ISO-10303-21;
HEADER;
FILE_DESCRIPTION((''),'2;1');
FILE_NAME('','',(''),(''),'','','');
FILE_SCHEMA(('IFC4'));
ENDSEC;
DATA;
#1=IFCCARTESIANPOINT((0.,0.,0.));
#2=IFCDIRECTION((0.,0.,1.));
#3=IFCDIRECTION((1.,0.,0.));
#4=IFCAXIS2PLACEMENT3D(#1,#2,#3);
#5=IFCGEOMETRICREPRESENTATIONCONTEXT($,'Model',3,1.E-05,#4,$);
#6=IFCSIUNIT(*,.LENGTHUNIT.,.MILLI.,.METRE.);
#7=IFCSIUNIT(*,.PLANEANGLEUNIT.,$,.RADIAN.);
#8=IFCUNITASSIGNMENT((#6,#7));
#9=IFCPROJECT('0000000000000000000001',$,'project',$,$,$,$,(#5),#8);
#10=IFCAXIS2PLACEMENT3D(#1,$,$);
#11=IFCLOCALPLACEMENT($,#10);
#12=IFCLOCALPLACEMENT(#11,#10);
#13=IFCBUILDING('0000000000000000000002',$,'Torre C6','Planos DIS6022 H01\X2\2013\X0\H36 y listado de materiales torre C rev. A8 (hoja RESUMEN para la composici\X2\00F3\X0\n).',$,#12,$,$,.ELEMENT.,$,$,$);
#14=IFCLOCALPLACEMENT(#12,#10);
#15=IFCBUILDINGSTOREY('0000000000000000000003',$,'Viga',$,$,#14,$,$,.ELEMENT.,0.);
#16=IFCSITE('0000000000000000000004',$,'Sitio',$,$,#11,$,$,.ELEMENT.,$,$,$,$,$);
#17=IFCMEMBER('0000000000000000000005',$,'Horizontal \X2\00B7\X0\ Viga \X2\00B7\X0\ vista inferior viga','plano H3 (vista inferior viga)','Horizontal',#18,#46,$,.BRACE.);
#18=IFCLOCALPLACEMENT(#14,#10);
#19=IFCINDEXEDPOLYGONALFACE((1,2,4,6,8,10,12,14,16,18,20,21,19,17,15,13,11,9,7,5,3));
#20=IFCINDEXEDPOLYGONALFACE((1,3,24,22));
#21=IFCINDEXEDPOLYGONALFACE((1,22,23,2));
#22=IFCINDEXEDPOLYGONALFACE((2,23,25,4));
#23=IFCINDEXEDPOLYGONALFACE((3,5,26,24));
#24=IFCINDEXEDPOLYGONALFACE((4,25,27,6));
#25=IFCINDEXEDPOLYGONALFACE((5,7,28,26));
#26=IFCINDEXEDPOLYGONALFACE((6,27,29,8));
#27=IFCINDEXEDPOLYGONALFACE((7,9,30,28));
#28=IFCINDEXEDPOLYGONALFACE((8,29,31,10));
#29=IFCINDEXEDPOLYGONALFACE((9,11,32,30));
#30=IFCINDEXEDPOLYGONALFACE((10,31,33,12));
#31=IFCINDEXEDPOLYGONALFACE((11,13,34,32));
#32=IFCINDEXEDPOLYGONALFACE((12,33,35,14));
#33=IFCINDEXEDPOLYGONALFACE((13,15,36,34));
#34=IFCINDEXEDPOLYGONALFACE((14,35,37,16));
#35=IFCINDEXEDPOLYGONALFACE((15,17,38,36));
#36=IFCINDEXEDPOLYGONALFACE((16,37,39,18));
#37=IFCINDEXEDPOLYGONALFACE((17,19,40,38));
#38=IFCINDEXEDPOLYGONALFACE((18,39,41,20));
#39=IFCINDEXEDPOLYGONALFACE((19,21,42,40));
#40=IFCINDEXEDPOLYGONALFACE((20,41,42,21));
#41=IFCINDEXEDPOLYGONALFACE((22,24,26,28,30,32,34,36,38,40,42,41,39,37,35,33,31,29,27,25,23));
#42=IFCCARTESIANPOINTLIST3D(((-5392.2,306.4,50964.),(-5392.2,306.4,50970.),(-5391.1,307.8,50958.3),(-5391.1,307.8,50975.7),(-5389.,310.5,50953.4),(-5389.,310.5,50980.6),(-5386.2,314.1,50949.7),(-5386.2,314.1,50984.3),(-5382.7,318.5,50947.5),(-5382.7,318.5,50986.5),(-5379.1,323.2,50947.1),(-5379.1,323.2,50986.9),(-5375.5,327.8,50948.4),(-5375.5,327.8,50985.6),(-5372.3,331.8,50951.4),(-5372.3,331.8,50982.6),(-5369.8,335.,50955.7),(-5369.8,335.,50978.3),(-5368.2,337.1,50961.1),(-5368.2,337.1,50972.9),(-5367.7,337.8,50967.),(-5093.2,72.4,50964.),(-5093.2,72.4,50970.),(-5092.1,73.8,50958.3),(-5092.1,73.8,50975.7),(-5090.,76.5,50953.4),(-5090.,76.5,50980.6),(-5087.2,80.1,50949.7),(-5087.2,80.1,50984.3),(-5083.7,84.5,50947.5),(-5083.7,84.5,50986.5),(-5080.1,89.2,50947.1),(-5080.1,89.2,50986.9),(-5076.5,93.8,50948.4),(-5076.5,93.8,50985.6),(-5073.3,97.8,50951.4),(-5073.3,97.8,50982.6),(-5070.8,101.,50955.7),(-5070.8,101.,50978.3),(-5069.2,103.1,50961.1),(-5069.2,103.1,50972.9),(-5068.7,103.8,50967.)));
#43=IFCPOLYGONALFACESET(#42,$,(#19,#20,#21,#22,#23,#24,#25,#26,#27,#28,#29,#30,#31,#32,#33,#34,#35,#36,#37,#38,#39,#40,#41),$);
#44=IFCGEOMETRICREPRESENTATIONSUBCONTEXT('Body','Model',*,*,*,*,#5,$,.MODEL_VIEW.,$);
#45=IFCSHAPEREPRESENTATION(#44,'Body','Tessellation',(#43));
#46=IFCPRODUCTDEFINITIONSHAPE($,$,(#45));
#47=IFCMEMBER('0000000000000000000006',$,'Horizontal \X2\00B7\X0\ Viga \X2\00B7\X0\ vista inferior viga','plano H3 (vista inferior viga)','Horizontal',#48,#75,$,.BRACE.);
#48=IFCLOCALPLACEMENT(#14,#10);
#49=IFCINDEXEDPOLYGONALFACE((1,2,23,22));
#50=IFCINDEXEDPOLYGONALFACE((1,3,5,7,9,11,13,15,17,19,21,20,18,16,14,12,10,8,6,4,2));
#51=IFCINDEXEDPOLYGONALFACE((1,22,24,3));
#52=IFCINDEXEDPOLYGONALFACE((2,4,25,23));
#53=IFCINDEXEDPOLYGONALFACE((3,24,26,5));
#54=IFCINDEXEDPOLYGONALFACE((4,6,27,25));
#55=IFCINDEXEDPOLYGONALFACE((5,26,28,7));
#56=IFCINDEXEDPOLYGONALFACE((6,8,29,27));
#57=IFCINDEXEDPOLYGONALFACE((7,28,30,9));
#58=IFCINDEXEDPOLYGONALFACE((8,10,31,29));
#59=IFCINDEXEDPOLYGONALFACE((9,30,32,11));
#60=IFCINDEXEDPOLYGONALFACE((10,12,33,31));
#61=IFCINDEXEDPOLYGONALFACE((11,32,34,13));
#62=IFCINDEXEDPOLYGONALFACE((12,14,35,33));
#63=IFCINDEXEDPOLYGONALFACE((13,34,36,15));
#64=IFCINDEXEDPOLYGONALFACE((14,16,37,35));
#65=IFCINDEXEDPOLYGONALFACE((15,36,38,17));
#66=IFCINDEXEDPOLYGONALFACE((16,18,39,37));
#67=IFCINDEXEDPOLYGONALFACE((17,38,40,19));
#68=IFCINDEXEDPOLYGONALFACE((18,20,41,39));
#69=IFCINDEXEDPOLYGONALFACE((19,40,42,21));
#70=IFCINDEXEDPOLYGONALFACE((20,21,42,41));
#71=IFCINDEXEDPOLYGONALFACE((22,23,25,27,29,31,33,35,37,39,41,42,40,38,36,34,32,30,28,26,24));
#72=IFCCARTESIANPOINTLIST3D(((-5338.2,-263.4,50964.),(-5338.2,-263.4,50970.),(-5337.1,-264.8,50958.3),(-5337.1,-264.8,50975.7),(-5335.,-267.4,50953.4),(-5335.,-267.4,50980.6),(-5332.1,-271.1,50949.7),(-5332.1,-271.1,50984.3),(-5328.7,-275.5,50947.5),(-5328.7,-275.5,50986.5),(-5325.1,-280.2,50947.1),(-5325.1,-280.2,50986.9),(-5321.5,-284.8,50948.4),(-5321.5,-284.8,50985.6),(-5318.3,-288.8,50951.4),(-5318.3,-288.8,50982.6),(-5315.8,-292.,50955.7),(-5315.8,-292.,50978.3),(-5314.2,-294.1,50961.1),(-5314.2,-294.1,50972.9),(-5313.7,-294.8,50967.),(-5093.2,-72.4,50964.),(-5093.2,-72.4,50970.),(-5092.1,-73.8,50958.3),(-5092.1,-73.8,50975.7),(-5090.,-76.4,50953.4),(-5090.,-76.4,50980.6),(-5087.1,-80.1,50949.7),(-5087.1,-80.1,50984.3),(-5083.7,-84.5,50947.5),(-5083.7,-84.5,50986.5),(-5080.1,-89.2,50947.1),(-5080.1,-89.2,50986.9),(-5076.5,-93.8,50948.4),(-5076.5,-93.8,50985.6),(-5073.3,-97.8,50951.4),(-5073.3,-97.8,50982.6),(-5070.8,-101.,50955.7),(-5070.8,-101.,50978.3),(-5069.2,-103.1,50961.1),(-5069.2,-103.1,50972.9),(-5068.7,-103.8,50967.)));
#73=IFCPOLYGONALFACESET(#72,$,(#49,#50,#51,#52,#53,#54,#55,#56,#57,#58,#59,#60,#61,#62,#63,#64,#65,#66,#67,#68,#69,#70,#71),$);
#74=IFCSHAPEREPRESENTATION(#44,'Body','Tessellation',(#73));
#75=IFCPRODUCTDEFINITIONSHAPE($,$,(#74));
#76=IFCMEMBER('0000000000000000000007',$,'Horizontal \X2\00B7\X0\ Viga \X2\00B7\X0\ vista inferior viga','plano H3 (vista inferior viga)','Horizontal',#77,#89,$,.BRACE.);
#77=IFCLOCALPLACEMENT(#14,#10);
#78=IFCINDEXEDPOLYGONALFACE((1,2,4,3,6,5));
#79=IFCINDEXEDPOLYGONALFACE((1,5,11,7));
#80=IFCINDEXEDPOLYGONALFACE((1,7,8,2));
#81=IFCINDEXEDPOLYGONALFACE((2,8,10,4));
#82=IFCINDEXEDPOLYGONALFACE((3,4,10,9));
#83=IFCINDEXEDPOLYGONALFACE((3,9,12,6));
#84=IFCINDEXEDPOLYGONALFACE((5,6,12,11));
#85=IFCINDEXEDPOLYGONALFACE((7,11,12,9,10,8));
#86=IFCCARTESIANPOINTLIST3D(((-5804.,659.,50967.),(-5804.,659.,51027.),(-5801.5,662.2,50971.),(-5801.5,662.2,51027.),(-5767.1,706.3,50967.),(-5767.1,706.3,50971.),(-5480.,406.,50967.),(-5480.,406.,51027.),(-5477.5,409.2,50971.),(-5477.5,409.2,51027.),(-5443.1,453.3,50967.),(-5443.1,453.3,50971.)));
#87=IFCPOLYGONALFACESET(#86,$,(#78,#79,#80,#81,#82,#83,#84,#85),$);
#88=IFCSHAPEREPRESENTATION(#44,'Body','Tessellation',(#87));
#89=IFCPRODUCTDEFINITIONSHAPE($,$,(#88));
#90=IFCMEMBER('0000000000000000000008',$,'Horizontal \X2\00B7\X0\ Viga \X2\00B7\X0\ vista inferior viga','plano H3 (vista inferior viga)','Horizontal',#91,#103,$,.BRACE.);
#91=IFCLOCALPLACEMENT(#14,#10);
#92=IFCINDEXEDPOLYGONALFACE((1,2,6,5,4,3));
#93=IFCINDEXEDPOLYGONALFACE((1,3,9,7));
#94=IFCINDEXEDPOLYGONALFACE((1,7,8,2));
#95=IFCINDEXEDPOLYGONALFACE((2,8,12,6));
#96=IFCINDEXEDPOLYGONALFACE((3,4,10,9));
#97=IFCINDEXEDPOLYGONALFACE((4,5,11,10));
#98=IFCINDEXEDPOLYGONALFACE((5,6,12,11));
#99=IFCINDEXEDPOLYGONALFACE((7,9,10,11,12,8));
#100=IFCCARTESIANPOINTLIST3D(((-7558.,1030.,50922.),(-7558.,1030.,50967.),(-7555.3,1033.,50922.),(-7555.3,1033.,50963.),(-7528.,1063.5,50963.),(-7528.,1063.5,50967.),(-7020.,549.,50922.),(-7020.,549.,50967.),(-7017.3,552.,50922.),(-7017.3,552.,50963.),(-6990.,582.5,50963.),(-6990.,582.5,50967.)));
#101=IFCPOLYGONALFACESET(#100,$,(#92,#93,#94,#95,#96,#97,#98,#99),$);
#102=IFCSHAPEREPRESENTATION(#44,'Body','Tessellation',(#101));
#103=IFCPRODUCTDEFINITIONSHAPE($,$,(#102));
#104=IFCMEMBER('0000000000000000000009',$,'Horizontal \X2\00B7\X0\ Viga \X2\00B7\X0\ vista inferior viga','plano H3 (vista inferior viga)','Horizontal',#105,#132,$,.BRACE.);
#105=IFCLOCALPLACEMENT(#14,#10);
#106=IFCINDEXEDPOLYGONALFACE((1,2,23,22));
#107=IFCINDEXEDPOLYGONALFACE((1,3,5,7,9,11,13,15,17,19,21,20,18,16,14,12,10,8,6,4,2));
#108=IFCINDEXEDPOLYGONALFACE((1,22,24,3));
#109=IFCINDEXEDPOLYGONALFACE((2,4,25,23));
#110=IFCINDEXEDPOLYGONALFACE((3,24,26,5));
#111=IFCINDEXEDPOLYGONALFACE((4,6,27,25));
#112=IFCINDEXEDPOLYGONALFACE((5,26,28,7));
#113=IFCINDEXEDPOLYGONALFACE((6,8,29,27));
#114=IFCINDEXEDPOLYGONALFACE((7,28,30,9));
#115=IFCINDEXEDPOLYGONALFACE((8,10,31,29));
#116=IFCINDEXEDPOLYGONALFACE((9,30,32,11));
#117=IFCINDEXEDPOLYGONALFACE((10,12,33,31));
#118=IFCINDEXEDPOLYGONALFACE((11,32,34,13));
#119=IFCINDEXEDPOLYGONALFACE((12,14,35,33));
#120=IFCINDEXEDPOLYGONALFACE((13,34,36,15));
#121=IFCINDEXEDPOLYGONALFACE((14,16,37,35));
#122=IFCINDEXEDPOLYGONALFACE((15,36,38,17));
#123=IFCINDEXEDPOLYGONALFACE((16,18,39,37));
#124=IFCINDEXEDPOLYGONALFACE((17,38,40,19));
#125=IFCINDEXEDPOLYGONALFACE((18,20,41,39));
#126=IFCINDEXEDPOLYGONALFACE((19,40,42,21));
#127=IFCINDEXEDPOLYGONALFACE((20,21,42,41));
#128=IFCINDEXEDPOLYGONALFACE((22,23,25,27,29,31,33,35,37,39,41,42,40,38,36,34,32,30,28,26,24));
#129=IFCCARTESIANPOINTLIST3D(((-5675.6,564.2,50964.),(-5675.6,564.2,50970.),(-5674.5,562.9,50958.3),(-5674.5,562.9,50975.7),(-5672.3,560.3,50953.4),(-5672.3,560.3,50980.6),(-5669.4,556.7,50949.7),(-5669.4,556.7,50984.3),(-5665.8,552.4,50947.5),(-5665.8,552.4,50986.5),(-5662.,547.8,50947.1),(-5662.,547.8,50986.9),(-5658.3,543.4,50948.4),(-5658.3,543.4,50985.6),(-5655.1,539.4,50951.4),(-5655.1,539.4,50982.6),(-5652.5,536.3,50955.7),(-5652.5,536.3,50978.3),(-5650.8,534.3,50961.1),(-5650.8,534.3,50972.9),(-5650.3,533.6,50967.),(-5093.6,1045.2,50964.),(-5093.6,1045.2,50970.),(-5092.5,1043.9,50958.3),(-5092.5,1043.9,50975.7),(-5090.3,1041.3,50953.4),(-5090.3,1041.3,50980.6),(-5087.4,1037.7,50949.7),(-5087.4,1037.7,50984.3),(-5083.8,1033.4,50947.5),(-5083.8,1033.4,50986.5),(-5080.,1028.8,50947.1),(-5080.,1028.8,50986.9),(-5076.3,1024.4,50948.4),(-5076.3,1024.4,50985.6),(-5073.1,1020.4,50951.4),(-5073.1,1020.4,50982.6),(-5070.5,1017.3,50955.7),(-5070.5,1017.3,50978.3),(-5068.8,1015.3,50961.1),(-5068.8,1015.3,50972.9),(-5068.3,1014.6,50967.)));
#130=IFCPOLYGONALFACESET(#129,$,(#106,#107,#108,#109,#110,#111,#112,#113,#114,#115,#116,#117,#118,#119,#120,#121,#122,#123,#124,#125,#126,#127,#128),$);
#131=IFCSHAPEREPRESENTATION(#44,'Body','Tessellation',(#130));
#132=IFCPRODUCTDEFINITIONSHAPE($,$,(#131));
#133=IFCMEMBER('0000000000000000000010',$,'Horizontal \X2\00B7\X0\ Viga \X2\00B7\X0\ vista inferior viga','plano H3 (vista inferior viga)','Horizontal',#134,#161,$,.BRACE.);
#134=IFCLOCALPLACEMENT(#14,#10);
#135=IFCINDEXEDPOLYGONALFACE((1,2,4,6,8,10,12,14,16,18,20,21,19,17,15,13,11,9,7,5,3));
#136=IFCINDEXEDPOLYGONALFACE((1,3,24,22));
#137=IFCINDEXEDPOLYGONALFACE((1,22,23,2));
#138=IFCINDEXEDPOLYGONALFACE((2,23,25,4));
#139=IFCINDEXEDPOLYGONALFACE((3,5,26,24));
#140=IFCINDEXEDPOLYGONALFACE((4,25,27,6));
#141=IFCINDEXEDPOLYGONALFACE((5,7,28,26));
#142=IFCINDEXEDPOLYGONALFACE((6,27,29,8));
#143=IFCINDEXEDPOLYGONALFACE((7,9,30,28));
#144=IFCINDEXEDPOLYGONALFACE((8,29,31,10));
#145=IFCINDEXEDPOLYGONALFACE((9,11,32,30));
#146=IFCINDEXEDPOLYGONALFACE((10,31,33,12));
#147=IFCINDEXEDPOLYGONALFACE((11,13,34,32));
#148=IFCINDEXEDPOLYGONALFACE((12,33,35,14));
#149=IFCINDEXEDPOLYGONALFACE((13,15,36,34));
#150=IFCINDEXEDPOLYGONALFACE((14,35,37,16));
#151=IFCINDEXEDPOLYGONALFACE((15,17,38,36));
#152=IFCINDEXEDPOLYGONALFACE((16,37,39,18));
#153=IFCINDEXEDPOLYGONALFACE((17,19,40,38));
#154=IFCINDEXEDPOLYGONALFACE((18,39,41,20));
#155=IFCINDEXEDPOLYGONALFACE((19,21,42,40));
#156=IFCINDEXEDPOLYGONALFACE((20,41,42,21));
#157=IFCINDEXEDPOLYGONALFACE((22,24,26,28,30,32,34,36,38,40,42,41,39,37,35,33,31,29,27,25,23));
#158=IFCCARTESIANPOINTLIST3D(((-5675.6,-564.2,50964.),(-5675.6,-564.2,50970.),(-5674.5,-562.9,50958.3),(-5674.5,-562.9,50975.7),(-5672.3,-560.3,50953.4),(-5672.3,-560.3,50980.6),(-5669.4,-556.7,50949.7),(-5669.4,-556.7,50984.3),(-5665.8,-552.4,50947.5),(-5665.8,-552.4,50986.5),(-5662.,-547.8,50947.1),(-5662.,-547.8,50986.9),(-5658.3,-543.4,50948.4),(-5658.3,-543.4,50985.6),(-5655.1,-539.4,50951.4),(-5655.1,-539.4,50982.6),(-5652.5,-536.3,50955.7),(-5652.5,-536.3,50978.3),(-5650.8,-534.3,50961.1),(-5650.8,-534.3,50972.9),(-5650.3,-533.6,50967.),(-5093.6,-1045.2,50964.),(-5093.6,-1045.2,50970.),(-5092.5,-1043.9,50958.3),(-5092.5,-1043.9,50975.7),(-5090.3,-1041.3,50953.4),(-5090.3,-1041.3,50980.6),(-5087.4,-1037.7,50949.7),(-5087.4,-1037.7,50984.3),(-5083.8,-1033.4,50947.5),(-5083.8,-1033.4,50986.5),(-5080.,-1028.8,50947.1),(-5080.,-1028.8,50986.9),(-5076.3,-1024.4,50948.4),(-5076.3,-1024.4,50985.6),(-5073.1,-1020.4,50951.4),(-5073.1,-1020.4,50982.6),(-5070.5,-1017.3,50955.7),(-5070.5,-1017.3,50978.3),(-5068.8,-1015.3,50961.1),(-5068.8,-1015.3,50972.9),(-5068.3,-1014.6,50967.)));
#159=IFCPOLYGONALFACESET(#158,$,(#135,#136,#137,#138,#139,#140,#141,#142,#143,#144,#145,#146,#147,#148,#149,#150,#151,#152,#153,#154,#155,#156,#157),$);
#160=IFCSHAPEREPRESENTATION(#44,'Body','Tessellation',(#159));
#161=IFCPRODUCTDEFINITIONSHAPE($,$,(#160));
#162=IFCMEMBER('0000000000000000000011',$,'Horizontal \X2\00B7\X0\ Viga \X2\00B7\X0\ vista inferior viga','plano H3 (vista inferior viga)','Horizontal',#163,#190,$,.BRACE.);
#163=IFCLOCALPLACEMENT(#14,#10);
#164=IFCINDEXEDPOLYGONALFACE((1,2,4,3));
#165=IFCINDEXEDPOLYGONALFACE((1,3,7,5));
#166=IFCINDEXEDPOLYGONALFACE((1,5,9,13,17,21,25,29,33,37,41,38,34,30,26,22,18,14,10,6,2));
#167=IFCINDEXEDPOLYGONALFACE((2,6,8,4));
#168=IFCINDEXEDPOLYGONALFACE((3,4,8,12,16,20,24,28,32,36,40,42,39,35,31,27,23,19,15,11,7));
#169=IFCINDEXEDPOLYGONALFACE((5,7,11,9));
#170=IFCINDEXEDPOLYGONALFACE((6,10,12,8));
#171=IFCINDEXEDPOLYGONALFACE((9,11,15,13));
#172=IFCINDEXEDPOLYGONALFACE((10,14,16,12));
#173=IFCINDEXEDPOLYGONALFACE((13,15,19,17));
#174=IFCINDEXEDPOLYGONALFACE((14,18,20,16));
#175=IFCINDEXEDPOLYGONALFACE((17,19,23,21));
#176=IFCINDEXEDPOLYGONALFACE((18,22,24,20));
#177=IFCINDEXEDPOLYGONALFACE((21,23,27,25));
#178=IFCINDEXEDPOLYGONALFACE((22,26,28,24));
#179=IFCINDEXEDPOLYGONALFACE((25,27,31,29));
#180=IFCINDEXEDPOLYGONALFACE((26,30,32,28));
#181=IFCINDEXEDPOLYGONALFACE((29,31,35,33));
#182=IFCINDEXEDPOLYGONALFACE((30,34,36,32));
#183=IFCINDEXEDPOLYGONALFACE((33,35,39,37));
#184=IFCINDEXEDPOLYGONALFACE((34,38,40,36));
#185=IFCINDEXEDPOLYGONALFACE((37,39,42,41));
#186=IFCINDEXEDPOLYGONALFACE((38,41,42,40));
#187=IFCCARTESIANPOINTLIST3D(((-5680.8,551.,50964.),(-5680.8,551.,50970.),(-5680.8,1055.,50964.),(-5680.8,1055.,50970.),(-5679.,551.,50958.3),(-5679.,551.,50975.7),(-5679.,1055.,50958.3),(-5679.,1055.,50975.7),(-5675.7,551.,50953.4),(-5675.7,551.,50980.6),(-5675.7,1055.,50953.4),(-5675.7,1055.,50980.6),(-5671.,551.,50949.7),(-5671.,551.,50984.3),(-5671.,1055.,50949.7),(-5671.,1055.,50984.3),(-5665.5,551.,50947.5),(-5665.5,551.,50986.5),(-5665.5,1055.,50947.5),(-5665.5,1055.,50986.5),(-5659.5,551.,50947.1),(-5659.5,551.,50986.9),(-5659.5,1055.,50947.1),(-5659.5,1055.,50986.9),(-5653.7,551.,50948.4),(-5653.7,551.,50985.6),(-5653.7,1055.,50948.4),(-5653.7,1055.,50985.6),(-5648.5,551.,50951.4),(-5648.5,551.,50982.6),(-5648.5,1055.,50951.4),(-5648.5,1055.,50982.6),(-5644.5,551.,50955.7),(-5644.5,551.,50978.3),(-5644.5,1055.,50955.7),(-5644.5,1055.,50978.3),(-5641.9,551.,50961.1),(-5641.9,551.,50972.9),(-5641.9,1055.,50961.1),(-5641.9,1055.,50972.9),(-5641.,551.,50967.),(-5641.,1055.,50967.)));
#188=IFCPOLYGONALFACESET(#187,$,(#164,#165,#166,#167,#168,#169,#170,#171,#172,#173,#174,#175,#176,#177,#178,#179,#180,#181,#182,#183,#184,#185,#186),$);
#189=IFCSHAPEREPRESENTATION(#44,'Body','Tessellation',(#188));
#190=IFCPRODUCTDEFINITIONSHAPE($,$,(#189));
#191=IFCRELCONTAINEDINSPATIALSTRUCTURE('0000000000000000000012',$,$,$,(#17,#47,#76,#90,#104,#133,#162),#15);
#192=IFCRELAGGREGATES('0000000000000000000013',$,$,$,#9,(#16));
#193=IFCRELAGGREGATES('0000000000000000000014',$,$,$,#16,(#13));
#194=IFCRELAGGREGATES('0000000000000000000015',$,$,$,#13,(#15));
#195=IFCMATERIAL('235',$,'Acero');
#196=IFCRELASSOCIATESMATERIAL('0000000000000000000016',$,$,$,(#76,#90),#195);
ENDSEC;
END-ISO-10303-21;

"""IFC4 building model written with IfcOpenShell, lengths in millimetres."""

from ifc_helpers import new_model, si_unit, frame, frame_2d, origin, origin_with_axes, place, context, subcontext, project, spatial, circle, l_section, extrude, material, element, save


model = new_model("IFC4")

# Units and contexts
model_context = context("Model", 3, precision=1e-05, world=origin_with_axes())
body_context = subcontext(model_context, "Body", "Model", "MODEL_VIEW")
ifc_project = project(units=[si_unit("LENGTHUNIT", "METRE", prefix="MILLI"), si_unit("PLANEANGLEUNIT", "RADIAN")], contexts=[model_context])

# Site, building, storey
site_placement = place(None, origin())
site = spatial("IfcSite", under=ifc_project, at=site_placement, Name="Sitio", CompositionType="ELEMENT")
building_placement = place(site_placement, origin())
building = spatial("IfcBuilding", under=site, at=building_placement, Name="Torre C6", Description="Planos DIS6022 H01–H36 y listado de materiales torre C rev. A8 (hoja RESUMEN para la composición).", CompositionType="ELEMENT")
storey_placement = place(building_placement, origin())
storey = spatial("IfcBuildingStorey", under=building, at=storey_placement, Name="Viga", CompositionType="ELEMENT", Elevation=0.0)

# Members
ifc_material_1 = material(Name="235", Category="Acero")
member_1_placement = place(storey_placement, frame((-5081.0, 88.0, 50967.0), z_axis=(-0.787505, 0.616308, 0.0), x_axis=(0.616308, 0.787505, 0.0)))
element("IfcMember", 1, at=member_1_placement, inside=storey, Name="Horizontal · Viga · vista inferior viga", Description="plano H3 (vista inferior viga)", ObjectType="Horizontal", PredefinedType="BRACE", context=body_context, shape_type="SweptSolid", body=[
    extrude(circle(Radius=20.0), None, (0.0, 0.0, 1.0), 379.7),
])
member_2_placement = place(storey_placement, frame((-5081.0, -88.0, 50967.0), z_axis=(-0.788658, -0.614832, 0.0), x_axis=(0.614832, -0.788658, 0.0)))
element("IfcMember", 2, at=member_2_placement, inside=storey, Name="Horizontal · Viga · vista inferior viga", Description="plano H3 (vista inferior viga)", ObjectType="Horizontal", PredefinedType="BRACE", context=body_context, shape_type="SweptSolid", body=[
    extrude(circle(Radius=20.0), None, (0.0, 0.0, 1.0), 310.7),
])
member_3_placement = place(storey_placement, frame((-5804.0, 659.0, 50967.0), z_axis=(0.788172, -0.615455, 0.0), x_axis=(0.615455, 0.788172, 0.0)))
element("IfcMember", 3, at=member_3_placement, inside=storey, material=ifc_material_1, Name="Horizontal · Viga · vista inferior viga", Description="plano H3 (vista inferior viga)", ObjectType="Horizontal", PredefinedType="BRACE", context=body_context, shape_type="SweptSolid", body=[
    extrude(l_section(Depth=60.0, Width=60.0, Thickness=4.0, at=frame_2d((30.0, 30.0))), None, (0.0, 0.0, 1.0), 411.1),
])
member_4_placement = place(storey_placement, frame((-7020.0, 549.0, 50967.0), z_axis=(-0.745495, 0.666511, 0.0), x_axis=(0.666511, 0.745495, 0.0)))
element("IfcMember", 4, at=member_4_placement, inside=storey, material=ifc_material_1, Name="Horizontal · Viga · vista inferior viga", Description="plano H3 (vista inferior viga)", ObjectType="Horizontal", PredefinedType="BRACE", context=body_context, shape_type="SweptSolid", body=[
    extrude(l_section(Depth=45.0, Width=45.0, Thickness=4.0, at=frame_2d((22.5, 22.5))), None, (0.0, 0.0, 1.0), 721.7),
])
for number, where, z_axis, x_axis, name in (
    (5, (-5663.0, 549.0, 50967.0), (0.77082, 0.637053, 0.0), (0.637053, -0.77082, 0.0), "Horizontal · Viga · vista inferior viga"),
    (6, (-5663.0, -549.0, 50967.0), (0.77082, -0.637053, 0.0), (0.637053, 0.77082, 0.0), "Horizontal · Viga · vista inferior viga"),
):
    element("IfcMember", number, at=place(storey_placement, frame(where, z_axis=z_axis, x_axis=x_axis)), inside=storey, Name=name, Description="plano H3 (vista inferior viga)", ObjectType="Horizontal", PredefinedType="BRACE", context=body_context, shape_type="SweptSolid", body=[
        extrude(circle(Radius=20.0), None, (0.0, 0.0, 1.0), 755.0),
    ])
member_5_placement = place(storey_placement, frame((-5661.0, 551.0, 50967.0), z_axis=(0.0, 1.0, 0.0), x_axis=(1.0, 0.0, 0.0)))
element("IfcMember", 7, at=member_5_placement, inside=storey, Name="Horizontal · Viga · vista inferior viga", Description="plano H3 (vista inferior viga)", ObjectType="Horizontal", PredefinedType="BRACE", context=body_context, shape_type="SweptSolid", body=[
    extrude(circle(Radius=20.0), None, (0.0, 0.0, 1.0), 504.0),
])

save(model, "model.ifc")
